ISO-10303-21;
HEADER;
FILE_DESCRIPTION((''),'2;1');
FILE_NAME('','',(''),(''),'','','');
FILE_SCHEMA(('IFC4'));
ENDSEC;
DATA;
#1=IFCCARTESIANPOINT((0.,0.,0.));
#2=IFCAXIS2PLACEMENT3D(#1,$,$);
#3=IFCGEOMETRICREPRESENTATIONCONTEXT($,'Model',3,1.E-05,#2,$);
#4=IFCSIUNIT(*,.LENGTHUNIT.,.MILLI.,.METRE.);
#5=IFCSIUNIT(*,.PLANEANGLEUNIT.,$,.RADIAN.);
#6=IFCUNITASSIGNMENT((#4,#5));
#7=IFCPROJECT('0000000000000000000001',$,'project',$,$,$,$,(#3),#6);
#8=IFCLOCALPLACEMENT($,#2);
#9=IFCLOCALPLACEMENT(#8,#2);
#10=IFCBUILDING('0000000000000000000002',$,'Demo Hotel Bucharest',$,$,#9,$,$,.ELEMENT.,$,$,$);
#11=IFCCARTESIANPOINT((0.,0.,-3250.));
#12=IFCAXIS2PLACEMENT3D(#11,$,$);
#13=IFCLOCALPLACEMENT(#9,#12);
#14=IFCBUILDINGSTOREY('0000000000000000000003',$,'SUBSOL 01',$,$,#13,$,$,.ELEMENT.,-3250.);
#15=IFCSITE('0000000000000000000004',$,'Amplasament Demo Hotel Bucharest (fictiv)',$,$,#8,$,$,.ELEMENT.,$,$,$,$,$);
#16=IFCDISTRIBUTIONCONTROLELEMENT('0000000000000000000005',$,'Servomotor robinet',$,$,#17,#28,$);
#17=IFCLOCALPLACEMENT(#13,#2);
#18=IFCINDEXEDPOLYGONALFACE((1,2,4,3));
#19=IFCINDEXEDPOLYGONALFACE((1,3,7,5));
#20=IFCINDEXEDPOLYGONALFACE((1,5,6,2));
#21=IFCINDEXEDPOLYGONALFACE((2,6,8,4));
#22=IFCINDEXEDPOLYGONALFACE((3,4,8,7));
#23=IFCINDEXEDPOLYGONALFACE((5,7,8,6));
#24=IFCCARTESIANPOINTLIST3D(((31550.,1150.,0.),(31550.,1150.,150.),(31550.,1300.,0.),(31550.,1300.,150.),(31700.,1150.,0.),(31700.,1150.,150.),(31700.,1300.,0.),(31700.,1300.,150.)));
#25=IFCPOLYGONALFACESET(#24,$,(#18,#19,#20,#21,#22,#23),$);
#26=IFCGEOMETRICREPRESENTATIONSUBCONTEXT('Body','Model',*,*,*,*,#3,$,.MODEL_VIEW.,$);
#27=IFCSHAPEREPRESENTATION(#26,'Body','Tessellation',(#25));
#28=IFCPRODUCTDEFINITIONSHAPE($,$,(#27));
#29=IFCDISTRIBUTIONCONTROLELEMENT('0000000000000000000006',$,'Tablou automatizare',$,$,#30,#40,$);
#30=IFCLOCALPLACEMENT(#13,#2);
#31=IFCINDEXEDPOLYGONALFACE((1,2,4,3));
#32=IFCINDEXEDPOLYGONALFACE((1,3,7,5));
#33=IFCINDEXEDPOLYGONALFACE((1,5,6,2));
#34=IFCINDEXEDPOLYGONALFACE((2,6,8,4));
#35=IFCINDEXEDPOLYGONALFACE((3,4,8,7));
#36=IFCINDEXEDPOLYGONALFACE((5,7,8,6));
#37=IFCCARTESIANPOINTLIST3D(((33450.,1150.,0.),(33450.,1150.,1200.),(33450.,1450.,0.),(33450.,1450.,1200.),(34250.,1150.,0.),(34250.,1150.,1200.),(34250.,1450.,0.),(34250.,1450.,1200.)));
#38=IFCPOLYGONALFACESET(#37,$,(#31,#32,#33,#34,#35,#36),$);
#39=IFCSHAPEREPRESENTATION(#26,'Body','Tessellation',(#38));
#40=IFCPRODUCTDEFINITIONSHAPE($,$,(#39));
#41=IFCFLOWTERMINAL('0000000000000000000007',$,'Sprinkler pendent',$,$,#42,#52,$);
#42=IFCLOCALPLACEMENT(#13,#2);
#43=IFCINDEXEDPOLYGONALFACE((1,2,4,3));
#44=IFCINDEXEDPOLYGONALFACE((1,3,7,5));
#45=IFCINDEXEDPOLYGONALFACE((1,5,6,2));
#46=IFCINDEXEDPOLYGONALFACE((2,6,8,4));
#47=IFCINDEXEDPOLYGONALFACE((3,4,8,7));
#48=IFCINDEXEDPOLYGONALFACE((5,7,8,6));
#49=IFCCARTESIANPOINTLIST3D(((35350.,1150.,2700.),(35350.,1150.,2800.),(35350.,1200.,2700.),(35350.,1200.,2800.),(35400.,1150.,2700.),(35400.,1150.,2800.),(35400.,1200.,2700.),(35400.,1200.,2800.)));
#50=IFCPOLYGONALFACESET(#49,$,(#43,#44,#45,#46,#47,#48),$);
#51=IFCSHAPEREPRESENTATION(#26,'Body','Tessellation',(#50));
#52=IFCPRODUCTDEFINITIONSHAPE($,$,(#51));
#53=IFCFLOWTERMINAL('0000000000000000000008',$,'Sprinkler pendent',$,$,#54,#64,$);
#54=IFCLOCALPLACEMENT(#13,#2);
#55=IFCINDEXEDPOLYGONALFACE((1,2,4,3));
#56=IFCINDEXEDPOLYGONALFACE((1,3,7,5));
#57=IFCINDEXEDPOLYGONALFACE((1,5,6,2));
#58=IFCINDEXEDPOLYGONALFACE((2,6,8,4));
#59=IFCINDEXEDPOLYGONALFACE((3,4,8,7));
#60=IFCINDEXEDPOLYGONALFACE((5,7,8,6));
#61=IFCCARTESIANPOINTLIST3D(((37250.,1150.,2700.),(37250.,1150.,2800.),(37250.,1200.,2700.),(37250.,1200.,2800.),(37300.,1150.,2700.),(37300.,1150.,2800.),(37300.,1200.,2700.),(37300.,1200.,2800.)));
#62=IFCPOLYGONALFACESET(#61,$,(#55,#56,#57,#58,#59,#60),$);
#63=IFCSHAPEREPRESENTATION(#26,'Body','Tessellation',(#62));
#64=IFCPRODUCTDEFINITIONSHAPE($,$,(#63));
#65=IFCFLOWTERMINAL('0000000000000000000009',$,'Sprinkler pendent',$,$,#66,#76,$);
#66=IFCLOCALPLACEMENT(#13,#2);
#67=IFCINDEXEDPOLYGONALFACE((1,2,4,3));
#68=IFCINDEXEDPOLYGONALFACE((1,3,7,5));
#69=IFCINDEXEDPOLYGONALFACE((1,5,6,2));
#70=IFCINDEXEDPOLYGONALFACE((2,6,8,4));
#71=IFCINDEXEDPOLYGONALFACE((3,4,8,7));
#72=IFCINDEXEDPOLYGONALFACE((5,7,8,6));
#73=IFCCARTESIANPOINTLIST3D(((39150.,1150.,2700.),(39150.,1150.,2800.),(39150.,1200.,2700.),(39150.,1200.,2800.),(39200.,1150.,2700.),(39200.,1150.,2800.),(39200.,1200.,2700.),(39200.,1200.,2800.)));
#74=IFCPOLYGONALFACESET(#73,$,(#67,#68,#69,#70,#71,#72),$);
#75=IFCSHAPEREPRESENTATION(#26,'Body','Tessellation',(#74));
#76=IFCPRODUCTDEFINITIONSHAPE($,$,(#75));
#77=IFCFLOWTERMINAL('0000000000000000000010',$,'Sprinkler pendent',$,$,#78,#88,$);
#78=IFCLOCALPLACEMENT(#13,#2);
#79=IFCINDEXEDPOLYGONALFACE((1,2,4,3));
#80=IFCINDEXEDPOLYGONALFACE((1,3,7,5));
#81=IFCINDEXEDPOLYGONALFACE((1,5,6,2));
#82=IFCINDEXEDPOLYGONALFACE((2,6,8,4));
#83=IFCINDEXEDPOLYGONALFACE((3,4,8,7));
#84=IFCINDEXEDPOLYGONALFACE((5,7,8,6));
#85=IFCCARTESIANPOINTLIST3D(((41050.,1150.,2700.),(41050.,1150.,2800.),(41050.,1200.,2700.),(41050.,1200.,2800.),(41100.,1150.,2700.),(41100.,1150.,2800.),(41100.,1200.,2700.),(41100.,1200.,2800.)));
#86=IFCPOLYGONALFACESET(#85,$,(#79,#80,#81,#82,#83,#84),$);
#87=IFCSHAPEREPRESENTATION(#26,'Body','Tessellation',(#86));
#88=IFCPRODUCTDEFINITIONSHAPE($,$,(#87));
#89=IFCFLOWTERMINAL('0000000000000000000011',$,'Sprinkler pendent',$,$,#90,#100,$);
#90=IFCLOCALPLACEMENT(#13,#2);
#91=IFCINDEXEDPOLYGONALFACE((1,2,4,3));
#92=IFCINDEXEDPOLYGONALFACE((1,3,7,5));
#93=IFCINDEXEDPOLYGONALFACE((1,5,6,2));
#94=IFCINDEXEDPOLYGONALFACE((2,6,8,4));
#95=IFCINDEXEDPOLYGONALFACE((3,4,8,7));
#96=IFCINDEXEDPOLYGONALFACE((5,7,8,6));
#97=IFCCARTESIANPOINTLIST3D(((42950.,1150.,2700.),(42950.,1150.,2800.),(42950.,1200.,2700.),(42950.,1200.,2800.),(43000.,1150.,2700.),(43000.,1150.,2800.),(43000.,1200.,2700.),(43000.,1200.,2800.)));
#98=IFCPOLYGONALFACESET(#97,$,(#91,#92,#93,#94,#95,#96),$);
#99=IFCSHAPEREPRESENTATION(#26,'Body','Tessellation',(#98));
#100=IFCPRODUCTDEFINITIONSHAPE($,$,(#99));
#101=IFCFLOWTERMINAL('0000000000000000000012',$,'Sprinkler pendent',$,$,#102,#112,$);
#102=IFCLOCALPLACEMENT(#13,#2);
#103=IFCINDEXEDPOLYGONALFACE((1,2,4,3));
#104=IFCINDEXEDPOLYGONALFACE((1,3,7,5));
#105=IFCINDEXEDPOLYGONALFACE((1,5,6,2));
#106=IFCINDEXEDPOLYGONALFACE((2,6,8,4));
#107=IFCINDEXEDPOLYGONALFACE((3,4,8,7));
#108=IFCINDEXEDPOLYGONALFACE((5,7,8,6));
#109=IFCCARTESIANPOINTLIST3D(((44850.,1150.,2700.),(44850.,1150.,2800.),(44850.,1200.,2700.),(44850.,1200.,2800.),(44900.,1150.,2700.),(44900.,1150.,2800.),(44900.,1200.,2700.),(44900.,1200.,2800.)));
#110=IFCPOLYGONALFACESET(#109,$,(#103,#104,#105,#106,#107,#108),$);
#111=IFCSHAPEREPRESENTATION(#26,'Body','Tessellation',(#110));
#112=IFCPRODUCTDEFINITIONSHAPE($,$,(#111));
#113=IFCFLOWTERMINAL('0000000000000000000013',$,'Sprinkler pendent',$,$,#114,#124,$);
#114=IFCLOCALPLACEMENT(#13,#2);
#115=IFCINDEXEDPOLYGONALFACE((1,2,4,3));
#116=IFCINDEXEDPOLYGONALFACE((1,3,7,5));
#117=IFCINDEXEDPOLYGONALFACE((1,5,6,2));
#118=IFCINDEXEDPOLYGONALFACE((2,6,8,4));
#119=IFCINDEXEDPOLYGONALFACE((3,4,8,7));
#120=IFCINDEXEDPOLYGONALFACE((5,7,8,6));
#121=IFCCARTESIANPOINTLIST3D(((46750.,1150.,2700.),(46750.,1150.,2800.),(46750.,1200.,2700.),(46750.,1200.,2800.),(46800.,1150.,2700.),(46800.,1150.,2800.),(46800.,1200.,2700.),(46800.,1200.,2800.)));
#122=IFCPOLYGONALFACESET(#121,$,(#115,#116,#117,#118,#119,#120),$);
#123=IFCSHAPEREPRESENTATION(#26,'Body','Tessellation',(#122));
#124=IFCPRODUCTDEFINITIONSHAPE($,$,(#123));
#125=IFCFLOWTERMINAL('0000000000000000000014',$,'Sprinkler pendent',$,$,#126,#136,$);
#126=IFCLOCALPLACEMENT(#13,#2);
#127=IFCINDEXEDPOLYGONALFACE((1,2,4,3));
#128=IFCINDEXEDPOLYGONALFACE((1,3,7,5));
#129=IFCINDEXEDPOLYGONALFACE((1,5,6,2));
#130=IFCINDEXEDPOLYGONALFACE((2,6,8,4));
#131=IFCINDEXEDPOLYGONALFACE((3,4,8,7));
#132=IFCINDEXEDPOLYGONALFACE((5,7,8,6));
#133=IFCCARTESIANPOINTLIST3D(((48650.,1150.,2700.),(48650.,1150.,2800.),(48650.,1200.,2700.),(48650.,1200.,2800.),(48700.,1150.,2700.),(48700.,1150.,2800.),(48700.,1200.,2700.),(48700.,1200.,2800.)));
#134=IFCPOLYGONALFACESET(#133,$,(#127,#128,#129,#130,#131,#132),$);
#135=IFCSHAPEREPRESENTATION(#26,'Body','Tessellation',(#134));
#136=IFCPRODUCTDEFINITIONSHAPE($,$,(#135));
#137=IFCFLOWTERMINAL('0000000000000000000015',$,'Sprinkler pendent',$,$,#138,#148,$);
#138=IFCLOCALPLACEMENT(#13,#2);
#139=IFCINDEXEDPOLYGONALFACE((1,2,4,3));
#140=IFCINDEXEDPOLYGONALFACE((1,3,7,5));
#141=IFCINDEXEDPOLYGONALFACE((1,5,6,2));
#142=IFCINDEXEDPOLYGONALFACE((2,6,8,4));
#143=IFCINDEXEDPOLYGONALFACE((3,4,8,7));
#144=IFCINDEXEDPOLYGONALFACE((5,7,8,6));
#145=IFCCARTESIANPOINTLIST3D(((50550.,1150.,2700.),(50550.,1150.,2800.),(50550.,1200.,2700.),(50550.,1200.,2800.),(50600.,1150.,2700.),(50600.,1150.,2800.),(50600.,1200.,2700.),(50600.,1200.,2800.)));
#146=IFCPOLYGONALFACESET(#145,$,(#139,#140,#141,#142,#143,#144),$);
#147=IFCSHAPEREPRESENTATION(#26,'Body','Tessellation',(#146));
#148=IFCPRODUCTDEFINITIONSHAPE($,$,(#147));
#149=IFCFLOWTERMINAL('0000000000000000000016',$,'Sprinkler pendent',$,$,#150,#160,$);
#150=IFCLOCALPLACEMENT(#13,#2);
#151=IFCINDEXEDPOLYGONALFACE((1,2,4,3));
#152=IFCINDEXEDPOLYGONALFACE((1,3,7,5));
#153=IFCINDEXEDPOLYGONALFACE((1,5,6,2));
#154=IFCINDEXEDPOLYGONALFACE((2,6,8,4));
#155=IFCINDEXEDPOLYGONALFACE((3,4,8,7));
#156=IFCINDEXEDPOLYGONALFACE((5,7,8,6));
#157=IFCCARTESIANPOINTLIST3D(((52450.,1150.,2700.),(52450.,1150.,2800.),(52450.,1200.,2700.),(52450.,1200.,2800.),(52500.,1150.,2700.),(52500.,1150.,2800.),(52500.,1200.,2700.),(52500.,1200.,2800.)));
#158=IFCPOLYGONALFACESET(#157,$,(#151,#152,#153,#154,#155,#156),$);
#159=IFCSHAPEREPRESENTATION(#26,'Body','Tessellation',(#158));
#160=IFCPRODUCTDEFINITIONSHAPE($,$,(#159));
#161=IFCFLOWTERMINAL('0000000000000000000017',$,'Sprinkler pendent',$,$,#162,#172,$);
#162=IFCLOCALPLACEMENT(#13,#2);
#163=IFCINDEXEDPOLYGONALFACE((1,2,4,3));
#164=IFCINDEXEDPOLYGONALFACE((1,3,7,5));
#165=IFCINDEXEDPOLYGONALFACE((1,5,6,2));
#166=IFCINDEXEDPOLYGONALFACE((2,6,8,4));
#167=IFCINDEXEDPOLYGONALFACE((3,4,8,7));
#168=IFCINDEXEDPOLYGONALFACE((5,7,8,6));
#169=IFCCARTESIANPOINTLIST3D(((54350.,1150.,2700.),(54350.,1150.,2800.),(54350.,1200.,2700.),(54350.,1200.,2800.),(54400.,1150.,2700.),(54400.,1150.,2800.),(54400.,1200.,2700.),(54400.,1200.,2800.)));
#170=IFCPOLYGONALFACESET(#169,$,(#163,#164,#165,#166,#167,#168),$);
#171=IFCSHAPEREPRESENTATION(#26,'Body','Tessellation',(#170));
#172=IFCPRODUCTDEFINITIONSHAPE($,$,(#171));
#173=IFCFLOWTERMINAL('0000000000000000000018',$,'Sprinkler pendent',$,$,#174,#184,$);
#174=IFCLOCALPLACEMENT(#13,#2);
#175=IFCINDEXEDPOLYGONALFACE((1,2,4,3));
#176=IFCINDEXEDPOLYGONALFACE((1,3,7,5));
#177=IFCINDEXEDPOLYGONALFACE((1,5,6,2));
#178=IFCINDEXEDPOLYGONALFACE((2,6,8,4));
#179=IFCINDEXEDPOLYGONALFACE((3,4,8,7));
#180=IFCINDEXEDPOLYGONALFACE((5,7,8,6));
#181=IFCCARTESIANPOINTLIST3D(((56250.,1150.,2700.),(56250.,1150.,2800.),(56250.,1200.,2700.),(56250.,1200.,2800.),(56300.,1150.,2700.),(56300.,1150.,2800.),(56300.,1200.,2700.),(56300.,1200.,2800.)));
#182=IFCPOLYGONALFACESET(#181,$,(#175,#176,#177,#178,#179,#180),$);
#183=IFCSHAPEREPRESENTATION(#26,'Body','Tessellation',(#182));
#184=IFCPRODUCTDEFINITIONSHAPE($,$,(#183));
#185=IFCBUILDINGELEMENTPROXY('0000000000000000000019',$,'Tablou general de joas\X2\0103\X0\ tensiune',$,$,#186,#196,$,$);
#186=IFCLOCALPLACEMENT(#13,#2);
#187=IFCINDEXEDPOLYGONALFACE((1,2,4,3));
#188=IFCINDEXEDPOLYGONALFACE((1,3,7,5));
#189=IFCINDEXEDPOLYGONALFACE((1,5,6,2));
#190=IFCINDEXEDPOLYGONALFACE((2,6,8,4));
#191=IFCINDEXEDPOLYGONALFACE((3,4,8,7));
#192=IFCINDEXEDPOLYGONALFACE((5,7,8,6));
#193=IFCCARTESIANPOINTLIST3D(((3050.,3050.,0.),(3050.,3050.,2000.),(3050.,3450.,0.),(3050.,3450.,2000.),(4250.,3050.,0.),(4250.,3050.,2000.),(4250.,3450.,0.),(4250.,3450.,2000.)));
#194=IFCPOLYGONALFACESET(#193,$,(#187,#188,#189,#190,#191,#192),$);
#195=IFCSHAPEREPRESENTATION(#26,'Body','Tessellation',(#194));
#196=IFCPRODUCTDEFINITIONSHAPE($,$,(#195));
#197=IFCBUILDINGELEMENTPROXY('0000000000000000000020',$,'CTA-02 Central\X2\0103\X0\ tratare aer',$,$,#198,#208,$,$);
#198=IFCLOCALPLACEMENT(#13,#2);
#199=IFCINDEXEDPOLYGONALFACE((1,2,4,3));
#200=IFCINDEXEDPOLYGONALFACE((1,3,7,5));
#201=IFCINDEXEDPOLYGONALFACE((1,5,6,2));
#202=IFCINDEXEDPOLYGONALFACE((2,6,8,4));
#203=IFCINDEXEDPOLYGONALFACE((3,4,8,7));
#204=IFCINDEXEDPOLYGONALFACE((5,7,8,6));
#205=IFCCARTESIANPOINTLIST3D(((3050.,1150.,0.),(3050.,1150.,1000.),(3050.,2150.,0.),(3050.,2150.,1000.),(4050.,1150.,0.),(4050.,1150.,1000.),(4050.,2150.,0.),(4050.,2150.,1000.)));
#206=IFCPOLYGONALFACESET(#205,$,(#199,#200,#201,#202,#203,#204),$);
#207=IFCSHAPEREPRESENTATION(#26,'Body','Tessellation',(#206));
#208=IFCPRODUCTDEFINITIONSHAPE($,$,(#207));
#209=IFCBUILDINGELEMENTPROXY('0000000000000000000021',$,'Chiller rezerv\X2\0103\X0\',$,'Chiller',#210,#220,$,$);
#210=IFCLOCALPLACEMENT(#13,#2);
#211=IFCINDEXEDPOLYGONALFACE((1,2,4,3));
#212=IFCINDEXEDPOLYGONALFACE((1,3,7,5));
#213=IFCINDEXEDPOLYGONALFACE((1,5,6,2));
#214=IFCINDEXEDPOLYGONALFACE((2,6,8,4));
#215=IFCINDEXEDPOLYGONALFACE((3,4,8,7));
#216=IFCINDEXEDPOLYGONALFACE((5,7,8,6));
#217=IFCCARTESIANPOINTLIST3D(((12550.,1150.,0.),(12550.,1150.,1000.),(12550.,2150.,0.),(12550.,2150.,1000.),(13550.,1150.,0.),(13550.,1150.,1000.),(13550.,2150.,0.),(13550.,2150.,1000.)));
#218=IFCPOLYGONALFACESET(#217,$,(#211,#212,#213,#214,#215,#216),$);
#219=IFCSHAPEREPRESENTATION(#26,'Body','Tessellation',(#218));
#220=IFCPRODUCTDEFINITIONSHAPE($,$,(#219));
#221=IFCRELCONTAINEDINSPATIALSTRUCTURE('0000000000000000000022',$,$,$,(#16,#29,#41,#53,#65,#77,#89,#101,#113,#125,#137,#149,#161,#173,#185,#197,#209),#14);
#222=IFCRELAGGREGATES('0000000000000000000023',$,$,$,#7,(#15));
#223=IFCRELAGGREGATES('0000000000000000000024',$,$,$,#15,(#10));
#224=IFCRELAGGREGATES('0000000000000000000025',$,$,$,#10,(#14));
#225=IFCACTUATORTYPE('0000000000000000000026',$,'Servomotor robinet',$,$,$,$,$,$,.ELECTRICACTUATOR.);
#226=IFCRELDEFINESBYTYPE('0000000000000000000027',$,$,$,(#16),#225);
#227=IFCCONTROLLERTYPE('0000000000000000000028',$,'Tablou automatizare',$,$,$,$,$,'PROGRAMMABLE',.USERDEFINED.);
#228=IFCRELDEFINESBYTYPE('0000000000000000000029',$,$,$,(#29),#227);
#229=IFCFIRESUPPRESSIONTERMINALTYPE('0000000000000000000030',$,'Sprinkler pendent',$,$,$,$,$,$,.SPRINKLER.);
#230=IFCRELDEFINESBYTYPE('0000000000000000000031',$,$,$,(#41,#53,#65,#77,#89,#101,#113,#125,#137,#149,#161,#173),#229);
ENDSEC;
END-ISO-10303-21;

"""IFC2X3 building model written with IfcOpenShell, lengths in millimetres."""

from ifc_helpers import new_model, si_unit, frame, frame_2d, origin, place, context, subcontext, project, spatial, rectangle, extrude, type_object, element, save


model = new_model("IFC2X3")

# Units and contexts
model_context = context("Model", 3, precision=1e-05, world=origin())
body_context = subcontext(model_context, "Body", "Model", "MODEL_VIEW")
ifc_project = project(units=[si_unit("LENGTHUNIT", "METRE", prefix="MILLI"), si_unit("PLANEANGLEUNIT", "RADIAN")], contexts=[model_context])

# Site, building, storey
site_placement = place(None, origin())
site = spatial("IfcSite", under=ifc_project, at=site_placement, Name="Amplasament Demo Hotel Bucharest (fictiv)", CompositionType="ELEMENT")
building_placement = place(site_placement, origin())
building = spatial("IfcBuilding", under=site, at=building_placement, Name="Demo Hotel Bucharest", CompositionType="ELEMENT")
storey_placement = place(building_placement, frame((0.0, 0.0, -3250.0)))
storey = spatial("IfcBuildingStorey", under=building, at=storey_placement, Name="SUBSOL 01", CompositionType="ELEMENT", Elevation=-3250.0)

# Distribution control elements
actuator_type = type_object("IfcActuatorType", Name="Servomotor robinet", PredefinedType="ELECTRICACTUATOR")
distribution_control_element_1_placement = place(storey_placement, frame((31550.0, 1150.0, 0.0)))
element("IfcDistributionControlElement", 1, at=distribution_control_element_1_placement, inside=storey, type_object=actuator_type, Name="Servomotor robinet", context=body_context, shape_type="SweptSolid", body=[
    extrude(rectangle(XDim=150.0, YDim=150.0, at=frame_2d((75.0, 75.0))), origin(), (0.0, 0.0, 1.0), 150.0),
])
controller_type = type_object("IfcControllerType", Name="Tablou automatizare", ElementType="PROGRAMMABLE", PredefinedType="USERDEFINED")
distribution_control_element_2_placement = place(storey_placement, frame((33450.0, 1150.0, 0.0)))
element("IfcDistributionControlElement", 2, at=distribution_control_element_2_placement, inside=storey, type_object=controller_type, Name="Tablou automatizare", context=body_context, shape_type="SweptSolid", body=[
    extrude(rectangle(XDim=800.0, YDim=300.0, at=frame_2d((400.0, 150.0))), origin(), (0.0, 0.0, 1.0), 1200.0),
])

# Flow terminals
fire_suppression_terminal_type = type_object("IfcFireSuppressionTerminalType", Name="Sprinkler pendent", PredefinedType="SPRINKLER")
for number, where, name in (
    (3, (35350.0, 1150.0, 2700.0), "Sprinkler pendent"),
    (4, (37250.0, 1150.0, 2700.0), "Sprinkler pendent"),
    (5, (39150.0, 1150.0, 2700.0), "Sprinkler pendent"),
    (6, (41050.0, 1150.0, 2700.0), "Sprinkler pendent"),
    (7, (42950.0, 1150.0, 2700.0), "Sprinkler pendent"),
    (8, (44850.0, 1150.0, 2700.0), "Sprinkler pendent"),
    (9, (46750.0, 1150.0, 2700.0), "Sprinkler pendent"),
    (10, (48650.0, 1150.0, 2700.0), "Sprinkler pendent"),
    (11, (50550.0, 1150.0, 2700.0), "Sprinkler pendent"),
    (12, (52450.0, 1150.0, 2700.0), "Sprinkler pendent"),
    (13, (54350.0, 1150.0, 2700.0), "Sprinkler pendent"),
    (14, (56250.0, 1150.0, 2700.0), "Sprinkler pendent"),
):
    element("IfcFlowTerminal", number, at=place(storey_placement, frame(where)), inside=storey, type_object=fire_suppression_terminal_type, Name=name, context=body_context, shape_type="SweptSolid", body=[
        extrude(rectangle(XDim=50.0, YDim=50.0, at=frame_2d((25.0, 25.0))), origin(), (0.0, 0.0, 1.0), 100.0),
    ])

# Electric distribution point
electric_distribution_point_placement = place(storey_placement, frame((3050.0, 3050.0, 0.0)))
element("IfcElectricDistributionPoint", 15, at=electric_distribution_point_placement, inside=storey, Name="Tablou general de joasă tensiune", DistributionPointFunction="SWITCHBOARD", context=body_context, shape_type="SweptSolid", body=[
    extrude(rectangle(XDim=1200.0, YDim=400.0, at=frame_2d((600.0, 200.0))), origin(), (0.0, 0.0, 1.0), 2000.0),
])

# Building element proxies
proxy_1_placement = place(storey_placement, frame((3050.0, 1150.0, 0.0)))
element("IfcBuildingElementProxy", 16, at=proxy_1_placement, inside=storey, Name="CTA-02 Centrală tratare aer", context=body_context, shape_type="SweptSolid", body=[
    extrude(rectangle(XDim=1000.0, YDim=1000.0, at=frame_2d((500.0, 500.0))), origin(), (0.0, 0.0, 1.0), 1000.0),
])
proxy_2_placement = place(storey_placement, frame((12550.0, 1150.0, 0.0)))
element("IfcBuildingElementProxy", 17, at=proxy_2_placement, inside=storey, Name="Chiller rezervă", ObjectType="Chiller", context=body_context, shape_type="SweptSolid", body=[
    extrude(rectangle(XDim=1000.0, YDim=1000.0, at=frame_2d((500.0, 500.0))), origin(), (0.0, 0.0, 1.0), 1000.0),
])

save(model, "model.ifc")
